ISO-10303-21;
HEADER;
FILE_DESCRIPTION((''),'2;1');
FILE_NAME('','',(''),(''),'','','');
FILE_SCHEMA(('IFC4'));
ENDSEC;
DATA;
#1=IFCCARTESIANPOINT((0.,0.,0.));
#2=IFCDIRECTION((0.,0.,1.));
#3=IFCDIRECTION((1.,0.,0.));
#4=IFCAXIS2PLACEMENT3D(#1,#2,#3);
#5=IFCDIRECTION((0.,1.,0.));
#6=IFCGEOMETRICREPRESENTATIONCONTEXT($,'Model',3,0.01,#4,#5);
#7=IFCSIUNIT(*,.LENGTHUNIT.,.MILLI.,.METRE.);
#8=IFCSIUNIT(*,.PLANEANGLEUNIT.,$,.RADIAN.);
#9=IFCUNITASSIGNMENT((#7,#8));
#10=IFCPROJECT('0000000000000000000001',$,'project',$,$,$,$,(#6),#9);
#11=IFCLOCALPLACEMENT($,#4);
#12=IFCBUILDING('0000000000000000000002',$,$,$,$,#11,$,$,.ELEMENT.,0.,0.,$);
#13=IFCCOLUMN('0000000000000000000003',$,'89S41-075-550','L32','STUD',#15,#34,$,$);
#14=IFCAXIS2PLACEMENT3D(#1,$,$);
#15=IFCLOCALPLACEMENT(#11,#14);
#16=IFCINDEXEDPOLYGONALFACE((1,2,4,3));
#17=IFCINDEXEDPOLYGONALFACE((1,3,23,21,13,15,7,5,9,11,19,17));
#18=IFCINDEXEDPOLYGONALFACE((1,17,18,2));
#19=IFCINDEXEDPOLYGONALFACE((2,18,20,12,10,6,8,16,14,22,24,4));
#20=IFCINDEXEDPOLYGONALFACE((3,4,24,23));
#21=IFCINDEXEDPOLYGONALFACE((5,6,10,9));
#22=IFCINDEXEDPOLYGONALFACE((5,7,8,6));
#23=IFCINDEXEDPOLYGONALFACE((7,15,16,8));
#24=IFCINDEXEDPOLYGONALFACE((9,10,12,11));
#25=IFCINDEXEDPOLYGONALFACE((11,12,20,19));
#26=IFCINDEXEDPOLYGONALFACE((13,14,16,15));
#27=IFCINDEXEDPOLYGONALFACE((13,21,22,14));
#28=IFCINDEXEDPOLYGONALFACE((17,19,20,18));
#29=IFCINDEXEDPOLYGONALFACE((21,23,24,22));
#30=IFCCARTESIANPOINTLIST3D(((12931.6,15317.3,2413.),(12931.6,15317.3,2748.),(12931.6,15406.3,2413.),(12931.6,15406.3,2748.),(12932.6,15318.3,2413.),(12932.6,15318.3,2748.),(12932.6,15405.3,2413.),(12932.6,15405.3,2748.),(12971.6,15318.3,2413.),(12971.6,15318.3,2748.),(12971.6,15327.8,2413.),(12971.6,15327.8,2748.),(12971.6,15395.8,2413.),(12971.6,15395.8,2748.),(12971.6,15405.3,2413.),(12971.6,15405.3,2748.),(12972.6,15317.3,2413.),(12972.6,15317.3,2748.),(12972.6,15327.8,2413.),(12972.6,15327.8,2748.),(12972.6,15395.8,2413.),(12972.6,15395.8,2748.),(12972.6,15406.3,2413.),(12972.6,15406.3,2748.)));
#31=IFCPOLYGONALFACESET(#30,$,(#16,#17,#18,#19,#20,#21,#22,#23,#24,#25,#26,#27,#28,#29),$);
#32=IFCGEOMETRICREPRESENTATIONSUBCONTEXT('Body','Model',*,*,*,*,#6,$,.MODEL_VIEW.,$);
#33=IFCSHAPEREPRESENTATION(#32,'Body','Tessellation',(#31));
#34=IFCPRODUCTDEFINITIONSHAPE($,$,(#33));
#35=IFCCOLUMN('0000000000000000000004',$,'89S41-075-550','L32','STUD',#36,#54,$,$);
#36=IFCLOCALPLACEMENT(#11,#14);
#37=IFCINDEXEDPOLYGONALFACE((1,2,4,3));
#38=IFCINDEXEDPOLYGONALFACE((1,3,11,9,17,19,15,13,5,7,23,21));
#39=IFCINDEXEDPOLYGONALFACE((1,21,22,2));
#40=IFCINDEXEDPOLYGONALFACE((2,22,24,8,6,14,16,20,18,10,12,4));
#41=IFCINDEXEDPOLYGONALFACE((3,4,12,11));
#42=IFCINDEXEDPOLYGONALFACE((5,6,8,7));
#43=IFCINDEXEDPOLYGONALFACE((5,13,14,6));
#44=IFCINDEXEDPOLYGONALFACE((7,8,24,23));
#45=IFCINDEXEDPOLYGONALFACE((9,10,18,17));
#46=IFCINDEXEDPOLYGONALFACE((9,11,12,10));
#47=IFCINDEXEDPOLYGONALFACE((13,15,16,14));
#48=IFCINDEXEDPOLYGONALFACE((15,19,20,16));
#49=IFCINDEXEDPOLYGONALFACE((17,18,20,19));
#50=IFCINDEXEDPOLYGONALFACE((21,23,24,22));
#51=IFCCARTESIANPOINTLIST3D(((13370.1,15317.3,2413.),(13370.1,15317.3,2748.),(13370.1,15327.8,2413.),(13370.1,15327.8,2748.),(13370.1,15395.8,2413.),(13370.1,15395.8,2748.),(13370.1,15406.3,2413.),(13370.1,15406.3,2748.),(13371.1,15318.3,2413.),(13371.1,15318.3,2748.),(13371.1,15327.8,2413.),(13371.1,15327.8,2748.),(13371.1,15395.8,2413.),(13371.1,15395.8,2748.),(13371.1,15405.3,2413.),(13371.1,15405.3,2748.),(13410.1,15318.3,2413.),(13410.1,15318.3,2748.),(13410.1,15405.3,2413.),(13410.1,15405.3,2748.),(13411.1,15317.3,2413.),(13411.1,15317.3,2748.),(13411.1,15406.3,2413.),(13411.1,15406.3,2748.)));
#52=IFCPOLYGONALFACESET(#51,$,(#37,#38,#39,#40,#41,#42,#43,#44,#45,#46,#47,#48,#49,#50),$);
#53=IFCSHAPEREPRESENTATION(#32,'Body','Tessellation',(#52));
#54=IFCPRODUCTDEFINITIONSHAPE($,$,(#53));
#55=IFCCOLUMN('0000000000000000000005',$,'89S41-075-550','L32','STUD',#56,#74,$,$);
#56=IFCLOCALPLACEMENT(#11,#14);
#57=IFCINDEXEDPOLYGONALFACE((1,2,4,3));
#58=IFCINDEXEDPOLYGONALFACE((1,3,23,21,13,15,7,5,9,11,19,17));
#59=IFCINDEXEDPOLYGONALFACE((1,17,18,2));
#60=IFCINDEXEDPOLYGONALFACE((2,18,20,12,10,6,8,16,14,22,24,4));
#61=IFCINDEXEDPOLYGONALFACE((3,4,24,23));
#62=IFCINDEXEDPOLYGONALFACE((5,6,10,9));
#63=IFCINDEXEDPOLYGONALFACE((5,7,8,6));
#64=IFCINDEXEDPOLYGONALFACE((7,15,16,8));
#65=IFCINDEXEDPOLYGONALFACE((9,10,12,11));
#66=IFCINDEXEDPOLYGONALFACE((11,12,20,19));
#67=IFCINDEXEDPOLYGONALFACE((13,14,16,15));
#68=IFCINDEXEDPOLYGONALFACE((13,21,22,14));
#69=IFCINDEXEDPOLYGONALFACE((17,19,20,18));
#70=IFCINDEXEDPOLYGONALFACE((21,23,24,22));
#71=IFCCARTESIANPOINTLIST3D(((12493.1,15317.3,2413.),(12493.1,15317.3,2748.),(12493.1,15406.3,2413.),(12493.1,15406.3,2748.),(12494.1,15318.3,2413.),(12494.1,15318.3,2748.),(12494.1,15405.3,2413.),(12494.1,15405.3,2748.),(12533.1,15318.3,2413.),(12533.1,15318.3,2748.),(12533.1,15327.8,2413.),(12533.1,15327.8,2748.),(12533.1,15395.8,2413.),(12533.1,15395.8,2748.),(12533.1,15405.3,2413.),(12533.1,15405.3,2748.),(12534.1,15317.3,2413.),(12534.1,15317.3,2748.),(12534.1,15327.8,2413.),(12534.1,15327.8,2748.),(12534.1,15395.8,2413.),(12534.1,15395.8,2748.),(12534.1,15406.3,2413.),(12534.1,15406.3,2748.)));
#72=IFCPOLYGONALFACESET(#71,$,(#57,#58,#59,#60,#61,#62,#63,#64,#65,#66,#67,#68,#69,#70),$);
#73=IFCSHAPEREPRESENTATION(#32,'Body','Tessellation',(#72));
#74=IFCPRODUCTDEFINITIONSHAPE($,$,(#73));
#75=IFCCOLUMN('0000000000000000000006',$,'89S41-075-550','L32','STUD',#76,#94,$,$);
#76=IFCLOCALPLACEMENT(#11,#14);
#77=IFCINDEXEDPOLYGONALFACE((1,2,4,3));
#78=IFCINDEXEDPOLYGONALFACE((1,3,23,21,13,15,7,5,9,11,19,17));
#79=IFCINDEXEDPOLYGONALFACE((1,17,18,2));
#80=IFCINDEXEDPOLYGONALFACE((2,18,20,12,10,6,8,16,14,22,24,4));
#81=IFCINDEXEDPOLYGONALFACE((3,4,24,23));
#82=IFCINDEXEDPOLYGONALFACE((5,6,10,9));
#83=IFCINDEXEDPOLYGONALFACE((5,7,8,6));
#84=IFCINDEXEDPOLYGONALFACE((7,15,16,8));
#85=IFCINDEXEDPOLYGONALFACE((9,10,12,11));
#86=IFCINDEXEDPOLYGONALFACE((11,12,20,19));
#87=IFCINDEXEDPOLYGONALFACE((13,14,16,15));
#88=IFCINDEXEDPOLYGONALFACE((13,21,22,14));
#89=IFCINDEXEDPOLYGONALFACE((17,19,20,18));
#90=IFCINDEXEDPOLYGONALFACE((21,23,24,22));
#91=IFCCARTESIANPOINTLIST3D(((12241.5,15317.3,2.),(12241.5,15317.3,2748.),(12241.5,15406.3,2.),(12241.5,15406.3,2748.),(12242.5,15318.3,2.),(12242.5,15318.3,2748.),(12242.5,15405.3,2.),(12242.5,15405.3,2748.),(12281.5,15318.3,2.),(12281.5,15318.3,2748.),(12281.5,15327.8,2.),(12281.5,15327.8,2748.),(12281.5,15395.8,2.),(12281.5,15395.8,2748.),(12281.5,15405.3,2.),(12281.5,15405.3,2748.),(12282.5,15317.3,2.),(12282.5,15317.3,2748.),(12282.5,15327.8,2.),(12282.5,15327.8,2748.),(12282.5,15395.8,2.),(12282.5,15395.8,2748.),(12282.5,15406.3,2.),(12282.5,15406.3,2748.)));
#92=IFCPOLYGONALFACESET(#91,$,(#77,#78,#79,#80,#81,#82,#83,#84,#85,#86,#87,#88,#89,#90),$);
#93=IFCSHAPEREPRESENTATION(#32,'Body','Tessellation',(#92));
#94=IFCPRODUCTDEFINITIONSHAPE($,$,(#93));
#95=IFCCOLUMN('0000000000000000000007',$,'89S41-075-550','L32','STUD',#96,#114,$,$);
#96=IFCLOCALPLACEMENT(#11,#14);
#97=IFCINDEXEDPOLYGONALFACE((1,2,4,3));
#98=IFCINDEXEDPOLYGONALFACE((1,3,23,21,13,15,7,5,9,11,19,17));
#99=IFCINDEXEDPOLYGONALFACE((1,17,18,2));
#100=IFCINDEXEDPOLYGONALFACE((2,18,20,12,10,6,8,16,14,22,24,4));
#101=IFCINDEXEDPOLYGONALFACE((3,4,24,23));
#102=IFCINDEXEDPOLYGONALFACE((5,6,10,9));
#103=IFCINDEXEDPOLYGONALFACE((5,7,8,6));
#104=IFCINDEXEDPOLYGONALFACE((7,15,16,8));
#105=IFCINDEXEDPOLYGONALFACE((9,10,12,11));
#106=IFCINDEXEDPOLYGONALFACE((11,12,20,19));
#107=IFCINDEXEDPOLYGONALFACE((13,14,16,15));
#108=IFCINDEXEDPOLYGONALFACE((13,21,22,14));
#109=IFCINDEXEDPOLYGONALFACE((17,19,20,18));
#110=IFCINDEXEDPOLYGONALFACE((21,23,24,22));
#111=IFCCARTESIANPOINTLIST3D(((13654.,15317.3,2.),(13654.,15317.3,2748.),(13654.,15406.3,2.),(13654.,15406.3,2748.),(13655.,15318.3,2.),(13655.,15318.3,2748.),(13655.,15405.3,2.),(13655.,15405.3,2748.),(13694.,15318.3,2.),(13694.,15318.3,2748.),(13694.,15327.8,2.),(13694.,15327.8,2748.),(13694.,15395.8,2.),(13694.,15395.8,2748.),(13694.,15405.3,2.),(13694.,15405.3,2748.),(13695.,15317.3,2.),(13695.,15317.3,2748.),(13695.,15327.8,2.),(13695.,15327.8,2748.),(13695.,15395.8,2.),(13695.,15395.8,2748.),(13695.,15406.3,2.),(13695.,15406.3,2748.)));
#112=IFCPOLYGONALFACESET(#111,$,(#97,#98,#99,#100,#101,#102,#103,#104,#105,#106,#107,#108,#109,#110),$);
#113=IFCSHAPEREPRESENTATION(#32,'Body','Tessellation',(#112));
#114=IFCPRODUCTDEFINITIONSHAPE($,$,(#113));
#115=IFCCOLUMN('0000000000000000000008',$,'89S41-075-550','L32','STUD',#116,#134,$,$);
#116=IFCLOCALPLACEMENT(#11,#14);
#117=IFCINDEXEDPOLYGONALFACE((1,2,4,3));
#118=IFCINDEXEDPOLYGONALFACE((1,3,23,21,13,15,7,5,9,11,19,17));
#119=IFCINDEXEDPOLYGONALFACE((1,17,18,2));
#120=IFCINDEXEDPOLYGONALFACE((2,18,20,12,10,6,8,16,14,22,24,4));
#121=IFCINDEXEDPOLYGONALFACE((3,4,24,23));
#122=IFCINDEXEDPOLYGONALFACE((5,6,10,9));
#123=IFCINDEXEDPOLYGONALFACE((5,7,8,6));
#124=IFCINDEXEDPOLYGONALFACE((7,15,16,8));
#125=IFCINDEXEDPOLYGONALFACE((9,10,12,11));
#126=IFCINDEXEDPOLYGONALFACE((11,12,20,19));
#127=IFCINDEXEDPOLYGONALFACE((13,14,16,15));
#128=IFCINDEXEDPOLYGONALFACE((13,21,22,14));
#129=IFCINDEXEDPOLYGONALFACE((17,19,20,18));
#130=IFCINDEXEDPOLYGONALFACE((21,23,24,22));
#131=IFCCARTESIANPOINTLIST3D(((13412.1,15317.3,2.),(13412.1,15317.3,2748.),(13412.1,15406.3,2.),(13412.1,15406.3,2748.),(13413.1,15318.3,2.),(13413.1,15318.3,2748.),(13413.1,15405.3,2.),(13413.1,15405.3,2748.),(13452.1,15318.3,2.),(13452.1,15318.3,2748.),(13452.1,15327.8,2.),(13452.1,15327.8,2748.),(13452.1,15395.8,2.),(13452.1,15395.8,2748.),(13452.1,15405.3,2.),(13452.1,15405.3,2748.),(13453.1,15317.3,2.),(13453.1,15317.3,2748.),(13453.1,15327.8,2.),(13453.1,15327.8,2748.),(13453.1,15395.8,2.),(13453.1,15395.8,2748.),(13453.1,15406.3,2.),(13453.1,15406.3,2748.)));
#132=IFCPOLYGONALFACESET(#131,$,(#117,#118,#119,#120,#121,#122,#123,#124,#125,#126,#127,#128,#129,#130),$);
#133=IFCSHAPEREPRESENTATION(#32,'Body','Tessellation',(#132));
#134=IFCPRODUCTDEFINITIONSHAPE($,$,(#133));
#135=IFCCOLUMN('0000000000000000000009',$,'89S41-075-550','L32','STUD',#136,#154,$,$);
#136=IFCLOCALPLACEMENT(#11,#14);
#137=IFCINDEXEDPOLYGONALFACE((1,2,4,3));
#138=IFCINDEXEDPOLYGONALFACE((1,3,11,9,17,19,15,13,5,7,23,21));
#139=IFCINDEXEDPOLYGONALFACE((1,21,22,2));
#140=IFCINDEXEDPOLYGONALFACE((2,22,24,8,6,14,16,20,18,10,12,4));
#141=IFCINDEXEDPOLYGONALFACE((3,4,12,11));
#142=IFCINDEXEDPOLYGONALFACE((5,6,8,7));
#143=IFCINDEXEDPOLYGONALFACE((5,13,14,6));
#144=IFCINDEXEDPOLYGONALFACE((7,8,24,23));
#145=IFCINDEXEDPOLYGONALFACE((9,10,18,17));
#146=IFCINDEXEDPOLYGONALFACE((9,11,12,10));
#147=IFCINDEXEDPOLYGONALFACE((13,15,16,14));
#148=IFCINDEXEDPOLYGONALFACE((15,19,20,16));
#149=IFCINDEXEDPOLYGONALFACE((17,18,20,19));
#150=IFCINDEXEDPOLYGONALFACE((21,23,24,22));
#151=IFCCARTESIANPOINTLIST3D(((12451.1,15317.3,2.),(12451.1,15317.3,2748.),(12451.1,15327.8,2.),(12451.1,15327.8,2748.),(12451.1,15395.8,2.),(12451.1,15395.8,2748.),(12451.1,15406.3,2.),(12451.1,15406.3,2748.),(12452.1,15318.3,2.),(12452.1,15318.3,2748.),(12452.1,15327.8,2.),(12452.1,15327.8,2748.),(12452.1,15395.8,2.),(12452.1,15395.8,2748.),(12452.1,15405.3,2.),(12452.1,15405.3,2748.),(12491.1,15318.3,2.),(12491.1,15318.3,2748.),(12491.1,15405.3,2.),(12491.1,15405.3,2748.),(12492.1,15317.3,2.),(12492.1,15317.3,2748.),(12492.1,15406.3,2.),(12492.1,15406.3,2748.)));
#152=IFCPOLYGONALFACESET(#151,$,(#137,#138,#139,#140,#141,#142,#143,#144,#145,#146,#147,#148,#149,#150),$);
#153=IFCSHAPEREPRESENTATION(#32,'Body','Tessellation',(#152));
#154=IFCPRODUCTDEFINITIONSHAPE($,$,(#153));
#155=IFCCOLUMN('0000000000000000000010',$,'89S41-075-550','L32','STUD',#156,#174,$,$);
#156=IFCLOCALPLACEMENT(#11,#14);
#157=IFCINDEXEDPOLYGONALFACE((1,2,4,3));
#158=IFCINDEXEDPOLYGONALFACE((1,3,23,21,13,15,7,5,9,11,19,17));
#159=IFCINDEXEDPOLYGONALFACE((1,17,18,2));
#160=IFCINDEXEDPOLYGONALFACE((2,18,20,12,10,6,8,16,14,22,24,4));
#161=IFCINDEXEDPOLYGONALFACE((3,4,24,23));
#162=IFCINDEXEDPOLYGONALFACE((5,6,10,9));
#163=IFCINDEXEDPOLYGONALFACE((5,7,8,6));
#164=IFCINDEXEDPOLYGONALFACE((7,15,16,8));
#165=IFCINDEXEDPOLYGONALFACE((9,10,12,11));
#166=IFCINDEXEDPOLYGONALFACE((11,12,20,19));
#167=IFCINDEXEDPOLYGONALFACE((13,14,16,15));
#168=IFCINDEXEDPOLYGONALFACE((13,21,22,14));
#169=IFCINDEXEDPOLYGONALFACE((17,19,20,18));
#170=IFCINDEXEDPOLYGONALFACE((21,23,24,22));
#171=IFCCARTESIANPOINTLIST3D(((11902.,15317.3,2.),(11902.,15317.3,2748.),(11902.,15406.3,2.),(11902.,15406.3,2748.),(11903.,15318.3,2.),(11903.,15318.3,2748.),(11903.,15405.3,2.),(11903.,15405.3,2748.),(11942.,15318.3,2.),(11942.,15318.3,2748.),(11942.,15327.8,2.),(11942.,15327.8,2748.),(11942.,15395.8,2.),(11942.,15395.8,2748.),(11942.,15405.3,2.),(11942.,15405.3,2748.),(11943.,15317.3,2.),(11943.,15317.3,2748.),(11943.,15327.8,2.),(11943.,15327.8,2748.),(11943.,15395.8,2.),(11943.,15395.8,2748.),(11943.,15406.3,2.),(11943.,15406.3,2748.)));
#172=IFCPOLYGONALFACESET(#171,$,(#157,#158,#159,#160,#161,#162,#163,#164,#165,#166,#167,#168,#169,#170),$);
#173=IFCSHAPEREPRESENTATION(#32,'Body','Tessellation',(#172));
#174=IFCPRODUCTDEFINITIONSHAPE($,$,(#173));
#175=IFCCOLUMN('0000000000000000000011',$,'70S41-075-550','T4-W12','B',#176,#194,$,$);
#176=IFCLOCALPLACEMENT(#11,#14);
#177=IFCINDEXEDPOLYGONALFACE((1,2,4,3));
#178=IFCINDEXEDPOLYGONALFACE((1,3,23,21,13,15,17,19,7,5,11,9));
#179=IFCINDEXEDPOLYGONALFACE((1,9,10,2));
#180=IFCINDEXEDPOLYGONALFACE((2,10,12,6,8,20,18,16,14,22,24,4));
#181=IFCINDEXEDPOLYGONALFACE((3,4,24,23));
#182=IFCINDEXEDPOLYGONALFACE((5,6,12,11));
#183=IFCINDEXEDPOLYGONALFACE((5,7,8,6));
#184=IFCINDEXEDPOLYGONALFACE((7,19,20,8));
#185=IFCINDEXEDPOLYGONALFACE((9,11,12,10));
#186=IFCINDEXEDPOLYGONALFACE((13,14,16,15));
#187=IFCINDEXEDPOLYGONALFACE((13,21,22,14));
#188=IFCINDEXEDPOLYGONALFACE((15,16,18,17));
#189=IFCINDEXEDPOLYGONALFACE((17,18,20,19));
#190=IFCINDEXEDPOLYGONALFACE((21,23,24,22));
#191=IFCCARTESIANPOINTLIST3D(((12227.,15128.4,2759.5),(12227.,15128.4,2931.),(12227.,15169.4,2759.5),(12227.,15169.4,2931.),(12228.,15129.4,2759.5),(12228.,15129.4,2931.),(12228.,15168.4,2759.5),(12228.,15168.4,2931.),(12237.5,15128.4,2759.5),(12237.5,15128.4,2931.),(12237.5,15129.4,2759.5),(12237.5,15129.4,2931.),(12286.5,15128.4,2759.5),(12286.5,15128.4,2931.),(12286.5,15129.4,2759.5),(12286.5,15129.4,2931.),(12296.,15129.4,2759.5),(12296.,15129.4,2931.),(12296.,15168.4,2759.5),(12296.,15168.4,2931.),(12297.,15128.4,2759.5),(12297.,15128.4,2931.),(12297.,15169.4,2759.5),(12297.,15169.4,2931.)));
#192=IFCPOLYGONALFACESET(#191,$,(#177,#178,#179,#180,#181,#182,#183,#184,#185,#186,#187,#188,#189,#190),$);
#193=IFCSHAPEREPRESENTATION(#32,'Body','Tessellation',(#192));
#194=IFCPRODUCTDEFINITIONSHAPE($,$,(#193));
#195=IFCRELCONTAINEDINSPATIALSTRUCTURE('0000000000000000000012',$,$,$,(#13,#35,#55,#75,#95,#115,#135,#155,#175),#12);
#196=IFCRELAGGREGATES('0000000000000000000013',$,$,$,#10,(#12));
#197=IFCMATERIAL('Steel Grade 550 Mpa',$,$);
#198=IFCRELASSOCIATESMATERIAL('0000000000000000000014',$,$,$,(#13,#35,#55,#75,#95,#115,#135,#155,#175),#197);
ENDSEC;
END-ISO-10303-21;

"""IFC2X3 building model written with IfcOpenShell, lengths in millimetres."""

from ifc_helpers import new_model, si_unit, direction, frame, origin, origin_with_axes, origin_2d_with_axis, place, context, subcontext, project, spatial, c_section, extrude, source, transform, mapped, material, element, save


model = new_model("IFC2X3")

# Units and contexts
model_context = context("Model", 3, precision=0.01, world=origin_with_axes(), true_north=direction((0.0, 1.0, 0.0)))
body_context = subcontext(model_context, "Body", "Model", "MODEL_VIEW")
ifc_project = project(units=[si_unit("LENGTHUNIT", "METRE", prefix="MILLI"), si_unit("PLANEANGLEUNIT", "RADIAN")], contexts=[model_context])

# Building
building_placement = place(None, origin_with_axes())
building = spatial("IfcBuilding", under=ifc_project, at=building_placement, CompositionType="ELEMENT", ElevationOfRefHeight=0.0, ElevationOfTerrain=0.0)

# Columns
ifc_material = material(Name="Steel Grade 550 Mpa")
shared_shape_1 = source(origin(), body_context, "Body", "SweptSolid", [
    extrude(c_section(Depth=89.0, Width=41.0, WallThickness=1.0, Girth=10.5, at=origin_2d_with_axis()), origin_with_axes(), (0.0, 0.0, 1.0), 335.0),
])
column_1_placement = place(None, frame((12952.1, 15361.8, 2413.0), z_axis=(0.0, 0.0, 1.0), x_axis=(1.0, 0.0, 0.0)))
element("IfcColumn", 1, at=column_1_placement, inside=building, material=ifc_material, Name="89S41-075-550", Description="L32", ObjectType="STUD", context=body_context, shape_type="MappedRepresentation", body=[
    mapped(shared_shape_1, transform((0.0, 0.0, 0.0), scale=1.0)),
])
shared_shape_2 = source(origin(), body_context, "Body", "SweptSolid", [
    extrude(c_section(Depth=89.0, Width=41.0, WallThickness=1.0, Girth=10.5, at=origin_2d_with_axis()), origin_with_axes(), (0.0, 0.0, 1.0), 335.0),
])
column_2_placement = place(None, frame((13390.6, 15361.8, 2413.0), z_axis=(0.0, 0.0, 1.0), x_axis=(-1.0, 0.0, 0.0)))
element("IfcColumn", 2, at=column_2_placement, inside=building, material=ifc_material, Name="89S41-075-550", Description="L32", ObjectType="STUD", context=body_context, shape_type="MappedRepresentation", body=[
    mapped(shared_shape_2, transform((0.0, 0.0, 0.0), scale=1.0)),
])
shared_shape_3 = source(origin(), body_context, "Body", "SweptSolid", [
    extrude(c_section(Depth=89.0, Width=41.0, WallThickness=1.0, Girth=10.5, at=origin_2d_with_axis()), origin_with_axes(), (0.0, 0.0, 1.0), 335.0),
])
column_3_placement = place(None, frame((12513.6, 15361.8, 2413.0), z_axis=(0.0, 0.0, 1.0), x_axis=(1.0, 0.0, 0.0)))
element("IfcColumn", 3, at=column_3_placement, inside=building, material=ifc_material, Name="89S41-075-550", Description="L32", ObjectType="STUD", context=body_context, shape_type="MappedRepresentation", body=[
    mapped(shared_shape_3, transform((0.0, 0.0, 0.0), scale=1.0)),
])
shared_shape_4 = source(origin(), body_context, "Body", "SweptSolid", [
    extrude(c_section(Depth=89.0, Width=41.0, WallThickness=1.0, Girth=10.5, at=origin_2d_with_axis()), origin_with_axes(), (0.0, 0.0, 1.0), 2746.0),
])
column_4_placement = place(None, frame((12262.0, 15361.8, 2.0), z_axis=(0.0, 0.0, 1.0), x_axis=(1.0, 0.0, 0.0)))
element("IfcColumn", 4, at=column_4_placement, inside=building, material=ifc_material, Name="89S41-075-550", Description="L32", ObjectType="STUD", context=body_context, shape_type="MappedRepresentation", body=[
    mapped(shared_shape_4, transform((0.0, 0.0, 0.0), scale=1.0)),
])
shared_shape_5 = source(origin(), body_context, "Body", "SweptSolid", [
    extrude(c_section(Depth=89.0, Width=41.0, WallThickness=1.0, Girth=10.5, at=origin_2d_with_axis()), origin_with_axes(), (0.0, 0.0, 1.0), 2746.0),
])
column_5_placement = place(None, frame((13674.5, 15361.8, 2.0), z_axis=(0.0, 0.0, 1.0), x_axis=(1.0, 0.0, 0.0)))
element("IfcColumn", 5, at=column_5_placement, inside=building, material=ifc_material, Name="89S41-075-550", Description="L32", ObjectType="STUD", context=body_context, shape_type="MappedRepresentation", body=[
    mapped(shared_shape_5, transform((0.0, 0.0, 0.0), scale=1.0)),
])
shared_shape_6 = source(origin(), body_context, "Body", "SweptSolid", [
    extrude(c_section(Depth=89.0, Width=41.0, WallThickness=1.0, Girth=10.5, at=origin_2d_with_axis()), origin_with_axes(), (0.0, 0.0, 1.0), 2746.0),
])
column_6_placement = place(None, frame((13432.6, 15361.8, 2.0), z_axis=(0.0, 0.0, 1.0), x_axis=(1.0, 0.0, 0.0)))
element("IfcColumn", 6, at=column_6_placement, inside=building, material=ifc_material, Name="89S41-075-550", Description="L32", ObjectType="STUD", context=body_context, shape_type="MappedRepresentation", body=[
    mapped(shared_shape_6, transform((0.0, 0.0, 0.0), scale=1.0)),
])
shared_shape_7 = source(origin(), body_context, "Body", "SweptSolid", [
    extrude(c_section(Depth=89.0, Width=41.0, WallThickness=1.0, Girth=10.5, at=origin_2d_with_axis()), origin_with_axes(), (0.0, 0.0, 1.0), 2746.0),
])
column_7_placement = place(None, frame((12471.6, 15361.8, 2.0), z_axis=(0.0, 0.0, 1.0), x_axis=(-1.0, 0.0, 0.0)))
element("IfcColumn", 7, at=column_7_placement, inside=building, material=ifc_material, Name="89S41-075-550", Description="L32", ObjectType="STUD", context=body_context, shape_type="MappedRepresentation", body=[
    mapped(shared_shape_7, transform((0.0, 0.0, 0.0), scale=1.0)),
])
shared_shape_8 = source(origin(), body_context, "Body", "SweptSolid", [
    extrude(c_section(Depth=89.0, Width=41.0, WallThickness=1.0, Girth=10.5, at=origin_2d_with_axis()), origin_with_axes(), (0.0, 0.0, 1.0), 2746.0),
])
column_8_placement = place(None, frame((11922.5, 15361.8, 2.0), z_axis=(0.0, 0.0, 1.0), x_axis=(1.0, 0.0, 0.0)))
element("IfcColumn", 8, at=column_8_placement, inside=building, material=ifc_material, Name="89S41-075-550", Description="L32", ObjectType="STUD", context=body_context, shape_type="MappedRepresentation", body=[
    mapped(shared_shape_8, transform((0.0, 0.0, 0.0), scale=1.0)),
])
shared_shape_9 = source(origin(), body_context, "Body", "SweptSolid", [
    extrude(c_section(Depth=70.0, Width=41.0, WallThickness=1.0, Girth=10.5, at=origin_2d_with_axis()), origin_with_axes(), (0.0, 0.0, 1.0), 171.5),
])
column_9_placement = place(None, frame((12262.0, 15148.9, 2759.5), z_axis=(0.0, 0.0, 1.0), x_axis=(0.0, -1.0, 0.0)))
element("IfcColumn", 9, at=column_9_placement, inside=building, material=ifc_material, Name="70S41-075-550", Description="T4-W12", ObjectType="B", context=body_context, shape_type="MappedRepresentation", body=[
    mapped(shared_shape_9, transform((0.0, 0.0, 0.0), scale=1.0)),
])

save(model, "model.ifc")
